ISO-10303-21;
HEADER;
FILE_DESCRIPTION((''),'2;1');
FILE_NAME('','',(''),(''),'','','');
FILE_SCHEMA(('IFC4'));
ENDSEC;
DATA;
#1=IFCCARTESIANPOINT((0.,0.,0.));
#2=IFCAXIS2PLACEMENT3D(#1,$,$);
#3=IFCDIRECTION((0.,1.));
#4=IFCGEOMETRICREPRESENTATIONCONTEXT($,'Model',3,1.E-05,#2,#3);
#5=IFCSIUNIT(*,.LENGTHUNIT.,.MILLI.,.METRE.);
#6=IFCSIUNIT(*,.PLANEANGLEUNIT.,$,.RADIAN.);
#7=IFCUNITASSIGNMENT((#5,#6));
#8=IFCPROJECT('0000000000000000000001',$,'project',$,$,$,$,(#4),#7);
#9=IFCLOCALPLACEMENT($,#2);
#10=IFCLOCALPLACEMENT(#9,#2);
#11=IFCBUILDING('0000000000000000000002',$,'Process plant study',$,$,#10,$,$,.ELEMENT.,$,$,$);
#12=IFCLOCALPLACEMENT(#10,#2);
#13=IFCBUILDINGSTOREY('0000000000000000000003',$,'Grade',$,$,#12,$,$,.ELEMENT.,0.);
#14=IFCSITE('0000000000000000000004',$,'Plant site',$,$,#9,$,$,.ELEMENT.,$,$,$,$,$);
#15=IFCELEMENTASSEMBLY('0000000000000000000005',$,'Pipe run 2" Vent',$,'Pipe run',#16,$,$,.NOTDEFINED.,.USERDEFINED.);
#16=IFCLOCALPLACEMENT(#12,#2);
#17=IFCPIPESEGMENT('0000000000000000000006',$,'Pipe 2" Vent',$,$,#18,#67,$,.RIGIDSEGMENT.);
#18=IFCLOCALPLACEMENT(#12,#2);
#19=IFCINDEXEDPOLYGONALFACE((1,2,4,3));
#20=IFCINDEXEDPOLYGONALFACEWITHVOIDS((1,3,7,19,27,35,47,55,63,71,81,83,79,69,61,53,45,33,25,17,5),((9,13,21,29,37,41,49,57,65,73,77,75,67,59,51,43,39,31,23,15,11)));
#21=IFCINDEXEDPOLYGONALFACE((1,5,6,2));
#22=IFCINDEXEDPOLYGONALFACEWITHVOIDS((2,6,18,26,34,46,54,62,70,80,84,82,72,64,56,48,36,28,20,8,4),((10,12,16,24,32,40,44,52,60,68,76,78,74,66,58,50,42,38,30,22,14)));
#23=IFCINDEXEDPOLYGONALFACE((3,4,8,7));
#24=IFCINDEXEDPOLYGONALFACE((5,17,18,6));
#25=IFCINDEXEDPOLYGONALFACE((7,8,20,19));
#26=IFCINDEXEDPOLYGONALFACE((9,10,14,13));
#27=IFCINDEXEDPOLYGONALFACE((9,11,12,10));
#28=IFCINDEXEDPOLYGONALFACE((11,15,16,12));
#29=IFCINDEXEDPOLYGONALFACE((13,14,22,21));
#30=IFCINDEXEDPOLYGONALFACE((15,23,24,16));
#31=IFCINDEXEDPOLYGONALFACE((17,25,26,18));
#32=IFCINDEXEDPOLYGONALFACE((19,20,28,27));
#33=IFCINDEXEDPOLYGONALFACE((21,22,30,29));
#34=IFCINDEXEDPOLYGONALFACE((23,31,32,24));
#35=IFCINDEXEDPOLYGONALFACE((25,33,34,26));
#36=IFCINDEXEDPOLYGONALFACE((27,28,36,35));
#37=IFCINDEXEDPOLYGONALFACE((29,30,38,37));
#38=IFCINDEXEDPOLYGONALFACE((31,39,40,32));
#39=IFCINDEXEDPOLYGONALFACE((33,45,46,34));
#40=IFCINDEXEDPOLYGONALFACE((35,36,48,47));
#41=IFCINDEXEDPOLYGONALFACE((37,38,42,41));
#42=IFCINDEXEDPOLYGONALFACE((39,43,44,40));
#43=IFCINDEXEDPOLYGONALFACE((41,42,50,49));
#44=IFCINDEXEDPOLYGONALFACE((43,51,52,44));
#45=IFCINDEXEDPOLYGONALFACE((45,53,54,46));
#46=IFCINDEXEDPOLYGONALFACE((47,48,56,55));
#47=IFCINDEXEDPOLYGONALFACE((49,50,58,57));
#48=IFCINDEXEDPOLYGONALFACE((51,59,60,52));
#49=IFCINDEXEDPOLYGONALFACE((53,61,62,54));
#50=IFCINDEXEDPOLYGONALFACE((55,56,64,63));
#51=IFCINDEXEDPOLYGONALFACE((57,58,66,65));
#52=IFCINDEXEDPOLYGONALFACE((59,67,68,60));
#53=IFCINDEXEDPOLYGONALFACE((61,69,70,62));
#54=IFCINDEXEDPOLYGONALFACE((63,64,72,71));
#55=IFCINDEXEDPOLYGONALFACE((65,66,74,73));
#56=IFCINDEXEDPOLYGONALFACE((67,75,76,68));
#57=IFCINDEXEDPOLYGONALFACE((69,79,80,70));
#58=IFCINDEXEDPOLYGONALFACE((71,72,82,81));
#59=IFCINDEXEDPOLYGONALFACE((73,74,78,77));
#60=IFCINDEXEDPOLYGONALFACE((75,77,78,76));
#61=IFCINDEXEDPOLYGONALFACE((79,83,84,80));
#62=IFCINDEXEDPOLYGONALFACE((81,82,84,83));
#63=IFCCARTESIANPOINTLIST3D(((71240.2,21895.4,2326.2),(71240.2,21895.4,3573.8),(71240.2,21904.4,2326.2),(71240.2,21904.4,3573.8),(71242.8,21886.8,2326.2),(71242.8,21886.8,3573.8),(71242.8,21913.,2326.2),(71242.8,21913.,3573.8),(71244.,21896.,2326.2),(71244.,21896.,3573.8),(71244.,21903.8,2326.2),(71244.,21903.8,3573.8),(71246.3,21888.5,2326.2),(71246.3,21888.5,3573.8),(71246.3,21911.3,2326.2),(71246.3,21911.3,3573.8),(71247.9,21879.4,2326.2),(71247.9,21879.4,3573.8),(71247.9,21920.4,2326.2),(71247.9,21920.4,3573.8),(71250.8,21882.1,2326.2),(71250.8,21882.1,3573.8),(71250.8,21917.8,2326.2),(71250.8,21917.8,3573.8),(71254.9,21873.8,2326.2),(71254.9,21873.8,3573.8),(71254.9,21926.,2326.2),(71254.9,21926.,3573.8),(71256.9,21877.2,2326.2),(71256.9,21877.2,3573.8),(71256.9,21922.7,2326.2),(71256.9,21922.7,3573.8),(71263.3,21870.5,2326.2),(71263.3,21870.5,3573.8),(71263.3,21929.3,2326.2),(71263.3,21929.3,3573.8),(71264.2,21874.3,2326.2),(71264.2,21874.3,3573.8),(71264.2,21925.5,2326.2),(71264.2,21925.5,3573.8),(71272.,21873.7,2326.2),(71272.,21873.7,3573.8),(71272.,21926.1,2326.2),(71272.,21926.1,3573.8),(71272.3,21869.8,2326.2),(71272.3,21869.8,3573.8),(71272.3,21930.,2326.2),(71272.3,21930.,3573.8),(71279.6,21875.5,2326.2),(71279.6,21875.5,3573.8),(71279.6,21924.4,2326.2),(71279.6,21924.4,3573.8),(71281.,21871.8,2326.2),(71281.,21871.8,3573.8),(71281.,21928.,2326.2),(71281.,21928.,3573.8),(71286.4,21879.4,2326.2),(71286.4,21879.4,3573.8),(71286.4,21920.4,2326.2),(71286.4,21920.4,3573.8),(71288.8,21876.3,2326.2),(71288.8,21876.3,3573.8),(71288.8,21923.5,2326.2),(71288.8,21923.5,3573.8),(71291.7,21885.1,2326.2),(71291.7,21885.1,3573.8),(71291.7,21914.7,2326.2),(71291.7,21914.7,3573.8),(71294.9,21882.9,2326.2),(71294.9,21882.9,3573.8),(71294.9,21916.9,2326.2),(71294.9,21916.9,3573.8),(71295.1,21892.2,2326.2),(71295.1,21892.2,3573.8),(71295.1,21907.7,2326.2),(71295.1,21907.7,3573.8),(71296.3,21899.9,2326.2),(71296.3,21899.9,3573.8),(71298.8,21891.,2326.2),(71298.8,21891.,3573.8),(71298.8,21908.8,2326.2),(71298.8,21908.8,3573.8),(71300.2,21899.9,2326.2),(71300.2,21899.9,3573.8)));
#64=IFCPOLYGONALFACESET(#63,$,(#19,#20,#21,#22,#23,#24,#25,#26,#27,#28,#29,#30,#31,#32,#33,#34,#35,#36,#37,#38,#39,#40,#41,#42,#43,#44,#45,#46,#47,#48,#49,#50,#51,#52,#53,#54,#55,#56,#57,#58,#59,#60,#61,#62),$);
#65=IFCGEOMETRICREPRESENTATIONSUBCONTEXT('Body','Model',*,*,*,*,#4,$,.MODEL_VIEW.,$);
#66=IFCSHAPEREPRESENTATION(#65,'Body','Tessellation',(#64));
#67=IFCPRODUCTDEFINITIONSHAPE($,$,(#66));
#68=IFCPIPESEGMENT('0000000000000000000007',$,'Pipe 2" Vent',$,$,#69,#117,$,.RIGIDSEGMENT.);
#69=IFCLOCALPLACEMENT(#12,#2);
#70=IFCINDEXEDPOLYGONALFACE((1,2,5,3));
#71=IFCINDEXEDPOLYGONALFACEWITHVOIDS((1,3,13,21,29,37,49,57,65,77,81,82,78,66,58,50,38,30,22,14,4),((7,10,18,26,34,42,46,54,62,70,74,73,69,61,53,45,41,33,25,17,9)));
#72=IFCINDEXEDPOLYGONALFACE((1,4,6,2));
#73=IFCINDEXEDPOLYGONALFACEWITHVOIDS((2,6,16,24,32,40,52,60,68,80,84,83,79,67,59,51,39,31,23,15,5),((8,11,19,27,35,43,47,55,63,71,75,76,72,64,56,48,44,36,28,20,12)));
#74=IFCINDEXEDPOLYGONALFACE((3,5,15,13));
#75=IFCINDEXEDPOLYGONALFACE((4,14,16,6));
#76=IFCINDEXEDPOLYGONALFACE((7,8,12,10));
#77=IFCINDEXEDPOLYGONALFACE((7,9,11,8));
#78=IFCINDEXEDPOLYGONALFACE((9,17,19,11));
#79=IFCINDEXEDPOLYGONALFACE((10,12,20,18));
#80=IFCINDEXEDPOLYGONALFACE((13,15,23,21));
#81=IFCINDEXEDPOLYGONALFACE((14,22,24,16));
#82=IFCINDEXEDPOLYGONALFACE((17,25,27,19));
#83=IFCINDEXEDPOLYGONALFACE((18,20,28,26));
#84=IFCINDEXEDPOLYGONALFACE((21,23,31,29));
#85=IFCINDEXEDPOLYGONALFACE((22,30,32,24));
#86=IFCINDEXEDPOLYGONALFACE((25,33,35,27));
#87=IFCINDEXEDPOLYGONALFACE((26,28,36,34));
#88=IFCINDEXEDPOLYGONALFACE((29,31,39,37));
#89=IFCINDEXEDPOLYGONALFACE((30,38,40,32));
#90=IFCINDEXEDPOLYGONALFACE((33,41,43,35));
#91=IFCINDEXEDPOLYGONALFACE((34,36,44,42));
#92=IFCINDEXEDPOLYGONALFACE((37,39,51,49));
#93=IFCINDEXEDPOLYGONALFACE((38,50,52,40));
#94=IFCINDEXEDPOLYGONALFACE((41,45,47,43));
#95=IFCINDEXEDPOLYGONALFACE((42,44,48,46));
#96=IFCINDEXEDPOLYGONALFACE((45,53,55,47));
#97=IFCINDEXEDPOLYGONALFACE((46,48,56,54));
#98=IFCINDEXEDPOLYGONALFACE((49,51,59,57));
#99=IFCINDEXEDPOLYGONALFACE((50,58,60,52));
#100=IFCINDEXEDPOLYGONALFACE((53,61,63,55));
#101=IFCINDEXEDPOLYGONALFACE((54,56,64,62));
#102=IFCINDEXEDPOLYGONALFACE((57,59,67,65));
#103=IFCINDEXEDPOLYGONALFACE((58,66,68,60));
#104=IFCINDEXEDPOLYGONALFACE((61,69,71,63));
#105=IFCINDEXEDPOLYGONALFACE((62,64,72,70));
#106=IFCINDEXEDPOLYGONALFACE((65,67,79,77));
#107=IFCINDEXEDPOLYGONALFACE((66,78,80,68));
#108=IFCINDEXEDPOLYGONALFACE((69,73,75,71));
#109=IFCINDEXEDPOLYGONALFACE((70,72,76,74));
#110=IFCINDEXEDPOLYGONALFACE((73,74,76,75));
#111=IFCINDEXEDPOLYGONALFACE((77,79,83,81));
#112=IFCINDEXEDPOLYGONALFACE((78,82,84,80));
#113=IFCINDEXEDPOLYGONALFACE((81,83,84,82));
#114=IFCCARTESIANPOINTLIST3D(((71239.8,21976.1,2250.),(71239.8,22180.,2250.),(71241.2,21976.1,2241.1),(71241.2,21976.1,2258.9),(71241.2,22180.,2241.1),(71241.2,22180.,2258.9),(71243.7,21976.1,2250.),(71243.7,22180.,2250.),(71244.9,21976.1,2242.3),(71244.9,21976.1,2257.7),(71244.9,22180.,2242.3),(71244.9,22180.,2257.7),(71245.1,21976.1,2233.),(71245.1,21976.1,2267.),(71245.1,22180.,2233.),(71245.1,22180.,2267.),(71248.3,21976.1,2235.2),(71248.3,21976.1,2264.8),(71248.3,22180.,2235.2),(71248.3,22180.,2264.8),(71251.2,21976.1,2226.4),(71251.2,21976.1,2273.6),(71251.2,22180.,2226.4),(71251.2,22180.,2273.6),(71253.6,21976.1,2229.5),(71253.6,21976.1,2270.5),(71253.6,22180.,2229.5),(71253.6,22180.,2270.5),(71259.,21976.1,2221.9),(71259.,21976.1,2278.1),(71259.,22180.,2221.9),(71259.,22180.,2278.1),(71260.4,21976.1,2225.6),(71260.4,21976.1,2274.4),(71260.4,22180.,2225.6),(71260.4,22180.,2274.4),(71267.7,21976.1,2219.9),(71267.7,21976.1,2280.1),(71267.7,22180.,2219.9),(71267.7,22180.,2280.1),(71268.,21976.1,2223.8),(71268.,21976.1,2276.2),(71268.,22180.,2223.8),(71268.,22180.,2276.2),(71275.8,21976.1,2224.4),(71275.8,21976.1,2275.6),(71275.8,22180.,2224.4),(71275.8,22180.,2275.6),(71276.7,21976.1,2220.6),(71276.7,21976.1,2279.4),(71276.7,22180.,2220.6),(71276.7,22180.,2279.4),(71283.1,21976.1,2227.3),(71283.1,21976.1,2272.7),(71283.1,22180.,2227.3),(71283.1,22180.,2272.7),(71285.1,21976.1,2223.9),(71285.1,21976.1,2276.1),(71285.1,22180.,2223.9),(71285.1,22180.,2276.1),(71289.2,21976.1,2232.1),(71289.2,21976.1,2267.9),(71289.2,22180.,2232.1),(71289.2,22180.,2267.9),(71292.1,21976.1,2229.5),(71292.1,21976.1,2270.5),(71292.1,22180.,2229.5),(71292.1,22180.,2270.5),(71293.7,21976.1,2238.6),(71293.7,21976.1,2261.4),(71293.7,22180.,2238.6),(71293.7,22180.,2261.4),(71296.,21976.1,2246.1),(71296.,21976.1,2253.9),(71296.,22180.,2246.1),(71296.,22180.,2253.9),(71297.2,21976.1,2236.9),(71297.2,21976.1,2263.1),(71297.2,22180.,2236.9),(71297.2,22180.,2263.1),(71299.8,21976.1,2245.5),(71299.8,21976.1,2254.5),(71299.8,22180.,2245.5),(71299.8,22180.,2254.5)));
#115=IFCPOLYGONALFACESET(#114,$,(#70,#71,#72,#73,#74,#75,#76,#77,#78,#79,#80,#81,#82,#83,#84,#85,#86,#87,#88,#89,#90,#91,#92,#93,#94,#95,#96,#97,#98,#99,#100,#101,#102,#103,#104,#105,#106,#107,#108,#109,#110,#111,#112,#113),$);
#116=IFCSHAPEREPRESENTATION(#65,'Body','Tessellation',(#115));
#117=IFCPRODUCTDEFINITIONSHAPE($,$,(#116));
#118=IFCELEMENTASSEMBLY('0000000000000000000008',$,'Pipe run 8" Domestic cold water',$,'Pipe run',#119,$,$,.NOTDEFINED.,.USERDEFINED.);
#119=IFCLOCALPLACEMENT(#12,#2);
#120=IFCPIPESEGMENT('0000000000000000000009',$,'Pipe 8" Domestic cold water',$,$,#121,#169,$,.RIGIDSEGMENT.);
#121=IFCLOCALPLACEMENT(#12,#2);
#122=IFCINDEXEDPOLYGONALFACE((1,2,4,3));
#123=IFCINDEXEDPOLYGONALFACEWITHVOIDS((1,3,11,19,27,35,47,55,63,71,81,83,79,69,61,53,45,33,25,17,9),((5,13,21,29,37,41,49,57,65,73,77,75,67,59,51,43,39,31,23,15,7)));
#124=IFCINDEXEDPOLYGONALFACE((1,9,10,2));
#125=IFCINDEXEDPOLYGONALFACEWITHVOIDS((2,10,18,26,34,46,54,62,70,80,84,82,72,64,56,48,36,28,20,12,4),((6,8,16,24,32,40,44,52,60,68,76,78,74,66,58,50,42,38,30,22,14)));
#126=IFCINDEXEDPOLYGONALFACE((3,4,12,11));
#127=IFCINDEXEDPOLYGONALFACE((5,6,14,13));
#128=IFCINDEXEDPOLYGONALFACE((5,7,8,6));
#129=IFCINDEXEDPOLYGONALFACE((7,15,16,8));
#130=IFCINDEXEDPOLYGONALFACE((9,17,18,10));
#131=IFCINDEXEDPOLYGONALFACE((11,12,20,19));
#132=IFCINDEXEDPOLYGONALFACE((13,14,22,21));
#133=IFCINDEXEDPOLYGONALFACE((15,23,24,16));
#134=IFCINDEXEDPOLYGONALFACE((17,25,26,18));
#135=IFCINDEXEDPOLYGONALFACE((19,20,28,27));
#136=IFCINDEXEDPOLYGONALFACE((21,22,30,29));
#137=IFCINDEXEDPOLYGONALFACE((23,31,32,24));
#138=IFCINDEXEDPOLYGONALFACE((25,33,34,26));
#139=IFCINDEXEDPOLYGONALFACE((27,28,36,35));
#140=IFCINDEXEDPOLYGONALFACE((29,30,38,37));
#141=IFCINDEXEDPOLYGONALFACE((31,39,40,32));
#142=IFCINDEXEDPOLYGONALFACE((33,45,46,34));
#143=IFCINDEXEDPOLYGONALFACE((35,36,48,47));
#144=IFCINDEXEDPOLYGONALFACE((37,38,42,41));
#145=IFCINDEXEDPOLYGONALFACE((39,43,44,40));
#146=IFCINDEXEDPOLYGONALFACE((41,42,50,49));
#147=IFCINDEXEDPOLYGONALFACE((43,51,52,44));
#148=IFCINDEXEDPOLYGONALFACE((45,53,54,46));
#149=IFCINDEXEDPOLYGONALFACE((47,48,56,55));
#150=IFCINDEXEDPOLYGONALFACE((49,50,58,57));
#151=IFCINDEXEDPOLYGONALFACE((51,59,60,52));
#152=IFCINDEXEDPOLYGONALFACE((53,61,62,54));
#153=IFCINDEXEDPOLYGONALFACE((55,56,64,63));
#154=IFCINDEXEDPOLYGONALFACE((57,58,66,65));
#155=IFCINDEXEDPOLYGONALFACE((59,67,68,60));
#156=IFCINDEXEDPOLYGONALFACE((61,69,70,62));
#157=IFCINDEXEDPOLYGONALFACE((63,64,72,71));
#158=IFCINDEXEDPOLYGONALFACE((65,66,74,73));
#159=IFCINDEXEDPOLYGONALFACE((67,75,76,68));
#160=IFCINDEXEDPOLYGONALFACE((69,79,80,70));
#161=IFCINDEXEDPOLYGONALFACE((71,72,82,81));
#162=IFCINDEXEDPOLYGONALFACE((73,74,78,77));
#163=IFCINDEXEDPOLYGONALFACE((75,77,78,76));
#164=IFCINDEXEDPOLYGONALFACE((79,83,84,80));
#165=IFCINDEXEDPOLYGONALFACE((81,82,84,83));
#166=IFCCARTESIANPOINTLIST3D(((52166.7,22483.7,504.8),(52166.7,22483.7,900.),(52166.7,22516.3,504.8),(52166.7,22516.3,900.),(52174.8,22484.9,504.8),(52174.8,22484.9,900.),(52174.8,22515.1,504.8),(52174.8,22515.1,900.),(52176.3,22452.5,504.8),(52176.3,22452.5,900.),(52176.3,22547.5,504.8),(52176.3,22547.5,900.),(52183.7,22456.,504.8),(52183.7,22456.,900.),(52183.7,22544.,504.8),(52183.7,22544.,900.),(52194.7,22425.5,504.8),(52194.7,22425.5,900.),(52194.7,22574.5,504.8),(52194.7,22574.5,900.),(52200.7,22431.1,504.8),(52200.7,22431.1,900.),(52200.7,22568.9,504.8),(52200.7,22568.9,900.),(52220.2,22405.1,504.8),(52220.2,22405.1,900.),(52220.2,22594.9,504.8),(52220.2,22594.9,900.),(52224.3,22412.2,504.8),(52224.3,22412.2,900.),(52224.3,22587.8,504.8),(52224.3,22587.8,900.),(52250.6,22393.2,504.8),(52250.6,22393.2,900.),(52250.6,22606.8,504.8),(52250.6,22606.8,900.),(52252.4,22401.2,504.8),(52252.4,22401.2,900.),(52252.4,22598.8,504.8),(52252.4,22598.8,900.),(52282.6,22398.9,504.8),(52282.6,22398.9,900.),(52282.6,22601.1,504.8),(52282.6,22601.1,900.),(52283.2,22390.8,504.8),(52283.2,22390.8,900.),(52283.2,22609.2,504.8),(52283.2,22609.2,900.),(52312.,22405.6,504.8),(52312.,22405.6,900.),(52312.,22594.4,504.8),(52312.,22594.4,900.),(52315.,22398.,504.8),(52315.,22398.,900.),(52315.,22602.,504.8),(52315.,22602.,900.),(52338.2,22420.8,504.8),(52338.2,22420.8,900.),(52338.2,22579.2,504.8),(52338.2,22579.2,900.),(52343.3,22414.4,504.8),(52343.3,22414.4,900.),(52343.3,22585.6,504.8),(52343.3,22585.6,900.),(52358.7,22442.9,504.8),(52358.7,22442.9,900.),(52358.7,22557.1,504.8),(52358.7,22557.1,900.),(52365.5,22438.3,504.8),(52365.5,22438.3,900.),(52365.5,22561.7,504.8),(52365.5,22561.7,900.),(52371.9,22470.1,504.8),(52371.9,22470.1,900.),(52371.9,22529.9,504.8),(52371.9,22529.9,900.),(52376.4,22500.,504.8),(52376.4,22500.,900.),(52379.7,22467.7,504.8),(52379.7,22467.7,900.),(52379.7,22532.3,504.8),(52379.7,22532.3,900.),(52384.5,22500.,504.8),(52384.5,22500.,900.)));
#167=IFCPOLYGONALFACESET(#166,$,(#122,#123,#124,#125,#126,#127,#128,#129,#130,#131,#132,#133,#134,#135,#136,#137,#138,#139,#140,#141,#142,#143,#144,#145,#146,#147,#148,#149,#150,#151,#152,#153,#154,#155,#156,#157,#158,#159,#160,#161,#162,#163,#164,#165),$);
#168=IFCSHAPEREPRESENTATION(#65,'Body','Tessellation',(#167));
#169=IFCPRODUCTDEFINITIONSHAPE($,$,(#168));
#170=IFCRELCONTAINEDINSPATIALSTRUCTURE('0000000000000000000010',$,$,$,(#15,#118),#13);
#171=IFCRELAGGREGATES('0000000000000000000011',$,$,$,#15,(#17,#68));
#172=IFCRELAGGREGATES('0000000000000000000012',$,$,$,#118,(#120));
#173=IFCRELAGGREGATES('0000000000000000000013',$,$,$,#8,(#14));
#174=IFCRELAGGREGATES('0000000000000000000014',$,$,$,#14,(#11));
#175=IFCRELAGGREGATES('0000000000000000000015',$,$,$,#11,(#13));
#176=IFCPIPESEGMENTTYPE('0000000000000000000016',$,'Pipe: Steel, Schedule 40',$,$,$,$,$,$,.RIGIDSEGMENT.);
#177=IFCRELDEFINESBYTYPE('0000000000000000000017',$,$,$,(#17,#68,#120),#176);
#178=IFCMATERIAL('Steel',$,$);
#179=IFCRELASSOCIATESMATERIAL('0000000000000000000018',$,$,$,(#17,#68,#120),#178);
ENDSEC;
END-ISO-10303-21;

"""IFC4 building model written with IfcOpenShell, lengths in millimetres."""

from ifc_helpers import new_model, si_unit, direction, frame, origin, origin_with_axes, origin_2d, place, context, subcontext, project, spatial, hollow_circle, extrude, material, type_object, element, aggregate, save


model = new_model("IFC4")

# Units and contexts
model_context = context("Model", 3, precision=1e-05, world=origin(), true_north=direction((0.0, 1.0)))
body_context = subcontext(model_context, "Body", "Model", "MODEL_VIEW")
ifc_project = project(units=[si_unit("LENGTHUNIT", "METRE", prefix="MILLI"), si_unit("PLANEANGLEUNIT", "RADIAN")], contexts=[model_context])

# Site, building, storey
site_placement = place(None, origin())
site = spatial("IfcSite", under=ifc_project, at=site_placement, Name="Plant site", CompositionType="ELEMENT")
building_placement = place(site_placement, origin())
building = spatial("IfcBuilding", under=site, at=building_placement, Name="Process plant study", CompositionType="ELEMENT")
storey_placement = place(building_placement, origin())
storey = spatial("IfcBuildingStorey", under=building, at=storey_placement, Name="Grade", CompositionType="ELEMENT", Elevation=0.0)

# Element assemblies, pipe segments
assembly_1_placement = place(storey_placement, origin_with_axes())
assembly_1 = element("IfcElementAssembly", 1, at=assembly_1_placement, inside=storey, Name="Pipe run 2\" Vent", ObjectType="Pipe run", AssemblyPlace="NOTDEFINED", PredefinedType="USERDEFINED")
ifc_material = material(Name="Steel")
pipe_segment_type = type_object("IfcPipeSegmentType", Name="Pipe: Steel, Schedule 40", PredefinedType="RIGIDSEGMENT")
pipe_segment_1_placement = place(storey_placement, origin_with_axes())
pipe_segment_1 = element("IfcPipeSegment", 2, at=pipe_segment_1_placement, type_object=pipe_segment_type, material=ifc_material, Name="Pipe 2\" Vent", PredefinedType="RIGIDSEGMENT", context=body_context, shape_type="SweptSolid", body=[
    extrude(hollow_circle(Radius=30.2, WallThickness=3.9, at=origin_2d()), frame((71270.0, 21899.9, 3573.8), z_axis=(0.0, 0.0, -1.0), x_axis=(1.0, 0.0, 0.0)), (0.0, 0.0, 1.0), 1247.6),
])
pipe_segment_2_placement = place(storey_placement, origin_with_axes())
pipe_segment_2 = element("IfcPipeSegment", 3, at=pipe_segment_2_placement, type_object=pipe_segment_type, material=ifc_material, Name="Pipe 2\" Vent", PredefinedType="RIGIDSEGMENT", context=body_context, shape_type="SweptSolid", body=[
    extrude(hollow_circle(Radius=30.2, WallThickness=3.9, at=origin_2d()), frame((71270.0, 21976.1, 2250.0), z_axis=(0.0, 1.0, 0.0), x_axis=(-1.0, 0.0, 0.0)), (0.0, 0.0, 1.0), 203.9),
])
assembly_2_placement = place(storey_placement, origin_with_axes())
assembly_2 = element("IfcElementAssembly", 4, at=assembly_2_placement, inside=storey, Name="Pipe run 8\" Domestic cold water", ObjectType="Pipe run", AssemblyPlace="NOTDEFINED", PredefinedType="USERDEFINED")
pipe_segment_3_placement = place(storey_placement, origin_with_axes())
pipe_segment_3 = element("IfcPipeSegment", 5, at=pipe_segment_3_placement, type_object=pipe_segment_type, material=ifc_material, Name="Pipe 8\" Domestic cold water", PredefinedType="RIGIDSEGMENT", context=body_context, shape_type="SweptSolid", body=[
    extrude(hollow_circle(Radius=109.5, WallThickness=8.2, at=origin_2d()), frame((52275.0, 22500.0, 900.0), z_axis=(0.0, 0.0, -1.0), x_axis=(1.0, 0.0, 0.0)), (0.0, 0.0, 1.0), 395.2),
])

aggregate(assembly_1, [pipe_segment_1, pipe_segment_2])
aggregate(assembly_2, [pipe_segment_3])

save(model, "model.ifc")
